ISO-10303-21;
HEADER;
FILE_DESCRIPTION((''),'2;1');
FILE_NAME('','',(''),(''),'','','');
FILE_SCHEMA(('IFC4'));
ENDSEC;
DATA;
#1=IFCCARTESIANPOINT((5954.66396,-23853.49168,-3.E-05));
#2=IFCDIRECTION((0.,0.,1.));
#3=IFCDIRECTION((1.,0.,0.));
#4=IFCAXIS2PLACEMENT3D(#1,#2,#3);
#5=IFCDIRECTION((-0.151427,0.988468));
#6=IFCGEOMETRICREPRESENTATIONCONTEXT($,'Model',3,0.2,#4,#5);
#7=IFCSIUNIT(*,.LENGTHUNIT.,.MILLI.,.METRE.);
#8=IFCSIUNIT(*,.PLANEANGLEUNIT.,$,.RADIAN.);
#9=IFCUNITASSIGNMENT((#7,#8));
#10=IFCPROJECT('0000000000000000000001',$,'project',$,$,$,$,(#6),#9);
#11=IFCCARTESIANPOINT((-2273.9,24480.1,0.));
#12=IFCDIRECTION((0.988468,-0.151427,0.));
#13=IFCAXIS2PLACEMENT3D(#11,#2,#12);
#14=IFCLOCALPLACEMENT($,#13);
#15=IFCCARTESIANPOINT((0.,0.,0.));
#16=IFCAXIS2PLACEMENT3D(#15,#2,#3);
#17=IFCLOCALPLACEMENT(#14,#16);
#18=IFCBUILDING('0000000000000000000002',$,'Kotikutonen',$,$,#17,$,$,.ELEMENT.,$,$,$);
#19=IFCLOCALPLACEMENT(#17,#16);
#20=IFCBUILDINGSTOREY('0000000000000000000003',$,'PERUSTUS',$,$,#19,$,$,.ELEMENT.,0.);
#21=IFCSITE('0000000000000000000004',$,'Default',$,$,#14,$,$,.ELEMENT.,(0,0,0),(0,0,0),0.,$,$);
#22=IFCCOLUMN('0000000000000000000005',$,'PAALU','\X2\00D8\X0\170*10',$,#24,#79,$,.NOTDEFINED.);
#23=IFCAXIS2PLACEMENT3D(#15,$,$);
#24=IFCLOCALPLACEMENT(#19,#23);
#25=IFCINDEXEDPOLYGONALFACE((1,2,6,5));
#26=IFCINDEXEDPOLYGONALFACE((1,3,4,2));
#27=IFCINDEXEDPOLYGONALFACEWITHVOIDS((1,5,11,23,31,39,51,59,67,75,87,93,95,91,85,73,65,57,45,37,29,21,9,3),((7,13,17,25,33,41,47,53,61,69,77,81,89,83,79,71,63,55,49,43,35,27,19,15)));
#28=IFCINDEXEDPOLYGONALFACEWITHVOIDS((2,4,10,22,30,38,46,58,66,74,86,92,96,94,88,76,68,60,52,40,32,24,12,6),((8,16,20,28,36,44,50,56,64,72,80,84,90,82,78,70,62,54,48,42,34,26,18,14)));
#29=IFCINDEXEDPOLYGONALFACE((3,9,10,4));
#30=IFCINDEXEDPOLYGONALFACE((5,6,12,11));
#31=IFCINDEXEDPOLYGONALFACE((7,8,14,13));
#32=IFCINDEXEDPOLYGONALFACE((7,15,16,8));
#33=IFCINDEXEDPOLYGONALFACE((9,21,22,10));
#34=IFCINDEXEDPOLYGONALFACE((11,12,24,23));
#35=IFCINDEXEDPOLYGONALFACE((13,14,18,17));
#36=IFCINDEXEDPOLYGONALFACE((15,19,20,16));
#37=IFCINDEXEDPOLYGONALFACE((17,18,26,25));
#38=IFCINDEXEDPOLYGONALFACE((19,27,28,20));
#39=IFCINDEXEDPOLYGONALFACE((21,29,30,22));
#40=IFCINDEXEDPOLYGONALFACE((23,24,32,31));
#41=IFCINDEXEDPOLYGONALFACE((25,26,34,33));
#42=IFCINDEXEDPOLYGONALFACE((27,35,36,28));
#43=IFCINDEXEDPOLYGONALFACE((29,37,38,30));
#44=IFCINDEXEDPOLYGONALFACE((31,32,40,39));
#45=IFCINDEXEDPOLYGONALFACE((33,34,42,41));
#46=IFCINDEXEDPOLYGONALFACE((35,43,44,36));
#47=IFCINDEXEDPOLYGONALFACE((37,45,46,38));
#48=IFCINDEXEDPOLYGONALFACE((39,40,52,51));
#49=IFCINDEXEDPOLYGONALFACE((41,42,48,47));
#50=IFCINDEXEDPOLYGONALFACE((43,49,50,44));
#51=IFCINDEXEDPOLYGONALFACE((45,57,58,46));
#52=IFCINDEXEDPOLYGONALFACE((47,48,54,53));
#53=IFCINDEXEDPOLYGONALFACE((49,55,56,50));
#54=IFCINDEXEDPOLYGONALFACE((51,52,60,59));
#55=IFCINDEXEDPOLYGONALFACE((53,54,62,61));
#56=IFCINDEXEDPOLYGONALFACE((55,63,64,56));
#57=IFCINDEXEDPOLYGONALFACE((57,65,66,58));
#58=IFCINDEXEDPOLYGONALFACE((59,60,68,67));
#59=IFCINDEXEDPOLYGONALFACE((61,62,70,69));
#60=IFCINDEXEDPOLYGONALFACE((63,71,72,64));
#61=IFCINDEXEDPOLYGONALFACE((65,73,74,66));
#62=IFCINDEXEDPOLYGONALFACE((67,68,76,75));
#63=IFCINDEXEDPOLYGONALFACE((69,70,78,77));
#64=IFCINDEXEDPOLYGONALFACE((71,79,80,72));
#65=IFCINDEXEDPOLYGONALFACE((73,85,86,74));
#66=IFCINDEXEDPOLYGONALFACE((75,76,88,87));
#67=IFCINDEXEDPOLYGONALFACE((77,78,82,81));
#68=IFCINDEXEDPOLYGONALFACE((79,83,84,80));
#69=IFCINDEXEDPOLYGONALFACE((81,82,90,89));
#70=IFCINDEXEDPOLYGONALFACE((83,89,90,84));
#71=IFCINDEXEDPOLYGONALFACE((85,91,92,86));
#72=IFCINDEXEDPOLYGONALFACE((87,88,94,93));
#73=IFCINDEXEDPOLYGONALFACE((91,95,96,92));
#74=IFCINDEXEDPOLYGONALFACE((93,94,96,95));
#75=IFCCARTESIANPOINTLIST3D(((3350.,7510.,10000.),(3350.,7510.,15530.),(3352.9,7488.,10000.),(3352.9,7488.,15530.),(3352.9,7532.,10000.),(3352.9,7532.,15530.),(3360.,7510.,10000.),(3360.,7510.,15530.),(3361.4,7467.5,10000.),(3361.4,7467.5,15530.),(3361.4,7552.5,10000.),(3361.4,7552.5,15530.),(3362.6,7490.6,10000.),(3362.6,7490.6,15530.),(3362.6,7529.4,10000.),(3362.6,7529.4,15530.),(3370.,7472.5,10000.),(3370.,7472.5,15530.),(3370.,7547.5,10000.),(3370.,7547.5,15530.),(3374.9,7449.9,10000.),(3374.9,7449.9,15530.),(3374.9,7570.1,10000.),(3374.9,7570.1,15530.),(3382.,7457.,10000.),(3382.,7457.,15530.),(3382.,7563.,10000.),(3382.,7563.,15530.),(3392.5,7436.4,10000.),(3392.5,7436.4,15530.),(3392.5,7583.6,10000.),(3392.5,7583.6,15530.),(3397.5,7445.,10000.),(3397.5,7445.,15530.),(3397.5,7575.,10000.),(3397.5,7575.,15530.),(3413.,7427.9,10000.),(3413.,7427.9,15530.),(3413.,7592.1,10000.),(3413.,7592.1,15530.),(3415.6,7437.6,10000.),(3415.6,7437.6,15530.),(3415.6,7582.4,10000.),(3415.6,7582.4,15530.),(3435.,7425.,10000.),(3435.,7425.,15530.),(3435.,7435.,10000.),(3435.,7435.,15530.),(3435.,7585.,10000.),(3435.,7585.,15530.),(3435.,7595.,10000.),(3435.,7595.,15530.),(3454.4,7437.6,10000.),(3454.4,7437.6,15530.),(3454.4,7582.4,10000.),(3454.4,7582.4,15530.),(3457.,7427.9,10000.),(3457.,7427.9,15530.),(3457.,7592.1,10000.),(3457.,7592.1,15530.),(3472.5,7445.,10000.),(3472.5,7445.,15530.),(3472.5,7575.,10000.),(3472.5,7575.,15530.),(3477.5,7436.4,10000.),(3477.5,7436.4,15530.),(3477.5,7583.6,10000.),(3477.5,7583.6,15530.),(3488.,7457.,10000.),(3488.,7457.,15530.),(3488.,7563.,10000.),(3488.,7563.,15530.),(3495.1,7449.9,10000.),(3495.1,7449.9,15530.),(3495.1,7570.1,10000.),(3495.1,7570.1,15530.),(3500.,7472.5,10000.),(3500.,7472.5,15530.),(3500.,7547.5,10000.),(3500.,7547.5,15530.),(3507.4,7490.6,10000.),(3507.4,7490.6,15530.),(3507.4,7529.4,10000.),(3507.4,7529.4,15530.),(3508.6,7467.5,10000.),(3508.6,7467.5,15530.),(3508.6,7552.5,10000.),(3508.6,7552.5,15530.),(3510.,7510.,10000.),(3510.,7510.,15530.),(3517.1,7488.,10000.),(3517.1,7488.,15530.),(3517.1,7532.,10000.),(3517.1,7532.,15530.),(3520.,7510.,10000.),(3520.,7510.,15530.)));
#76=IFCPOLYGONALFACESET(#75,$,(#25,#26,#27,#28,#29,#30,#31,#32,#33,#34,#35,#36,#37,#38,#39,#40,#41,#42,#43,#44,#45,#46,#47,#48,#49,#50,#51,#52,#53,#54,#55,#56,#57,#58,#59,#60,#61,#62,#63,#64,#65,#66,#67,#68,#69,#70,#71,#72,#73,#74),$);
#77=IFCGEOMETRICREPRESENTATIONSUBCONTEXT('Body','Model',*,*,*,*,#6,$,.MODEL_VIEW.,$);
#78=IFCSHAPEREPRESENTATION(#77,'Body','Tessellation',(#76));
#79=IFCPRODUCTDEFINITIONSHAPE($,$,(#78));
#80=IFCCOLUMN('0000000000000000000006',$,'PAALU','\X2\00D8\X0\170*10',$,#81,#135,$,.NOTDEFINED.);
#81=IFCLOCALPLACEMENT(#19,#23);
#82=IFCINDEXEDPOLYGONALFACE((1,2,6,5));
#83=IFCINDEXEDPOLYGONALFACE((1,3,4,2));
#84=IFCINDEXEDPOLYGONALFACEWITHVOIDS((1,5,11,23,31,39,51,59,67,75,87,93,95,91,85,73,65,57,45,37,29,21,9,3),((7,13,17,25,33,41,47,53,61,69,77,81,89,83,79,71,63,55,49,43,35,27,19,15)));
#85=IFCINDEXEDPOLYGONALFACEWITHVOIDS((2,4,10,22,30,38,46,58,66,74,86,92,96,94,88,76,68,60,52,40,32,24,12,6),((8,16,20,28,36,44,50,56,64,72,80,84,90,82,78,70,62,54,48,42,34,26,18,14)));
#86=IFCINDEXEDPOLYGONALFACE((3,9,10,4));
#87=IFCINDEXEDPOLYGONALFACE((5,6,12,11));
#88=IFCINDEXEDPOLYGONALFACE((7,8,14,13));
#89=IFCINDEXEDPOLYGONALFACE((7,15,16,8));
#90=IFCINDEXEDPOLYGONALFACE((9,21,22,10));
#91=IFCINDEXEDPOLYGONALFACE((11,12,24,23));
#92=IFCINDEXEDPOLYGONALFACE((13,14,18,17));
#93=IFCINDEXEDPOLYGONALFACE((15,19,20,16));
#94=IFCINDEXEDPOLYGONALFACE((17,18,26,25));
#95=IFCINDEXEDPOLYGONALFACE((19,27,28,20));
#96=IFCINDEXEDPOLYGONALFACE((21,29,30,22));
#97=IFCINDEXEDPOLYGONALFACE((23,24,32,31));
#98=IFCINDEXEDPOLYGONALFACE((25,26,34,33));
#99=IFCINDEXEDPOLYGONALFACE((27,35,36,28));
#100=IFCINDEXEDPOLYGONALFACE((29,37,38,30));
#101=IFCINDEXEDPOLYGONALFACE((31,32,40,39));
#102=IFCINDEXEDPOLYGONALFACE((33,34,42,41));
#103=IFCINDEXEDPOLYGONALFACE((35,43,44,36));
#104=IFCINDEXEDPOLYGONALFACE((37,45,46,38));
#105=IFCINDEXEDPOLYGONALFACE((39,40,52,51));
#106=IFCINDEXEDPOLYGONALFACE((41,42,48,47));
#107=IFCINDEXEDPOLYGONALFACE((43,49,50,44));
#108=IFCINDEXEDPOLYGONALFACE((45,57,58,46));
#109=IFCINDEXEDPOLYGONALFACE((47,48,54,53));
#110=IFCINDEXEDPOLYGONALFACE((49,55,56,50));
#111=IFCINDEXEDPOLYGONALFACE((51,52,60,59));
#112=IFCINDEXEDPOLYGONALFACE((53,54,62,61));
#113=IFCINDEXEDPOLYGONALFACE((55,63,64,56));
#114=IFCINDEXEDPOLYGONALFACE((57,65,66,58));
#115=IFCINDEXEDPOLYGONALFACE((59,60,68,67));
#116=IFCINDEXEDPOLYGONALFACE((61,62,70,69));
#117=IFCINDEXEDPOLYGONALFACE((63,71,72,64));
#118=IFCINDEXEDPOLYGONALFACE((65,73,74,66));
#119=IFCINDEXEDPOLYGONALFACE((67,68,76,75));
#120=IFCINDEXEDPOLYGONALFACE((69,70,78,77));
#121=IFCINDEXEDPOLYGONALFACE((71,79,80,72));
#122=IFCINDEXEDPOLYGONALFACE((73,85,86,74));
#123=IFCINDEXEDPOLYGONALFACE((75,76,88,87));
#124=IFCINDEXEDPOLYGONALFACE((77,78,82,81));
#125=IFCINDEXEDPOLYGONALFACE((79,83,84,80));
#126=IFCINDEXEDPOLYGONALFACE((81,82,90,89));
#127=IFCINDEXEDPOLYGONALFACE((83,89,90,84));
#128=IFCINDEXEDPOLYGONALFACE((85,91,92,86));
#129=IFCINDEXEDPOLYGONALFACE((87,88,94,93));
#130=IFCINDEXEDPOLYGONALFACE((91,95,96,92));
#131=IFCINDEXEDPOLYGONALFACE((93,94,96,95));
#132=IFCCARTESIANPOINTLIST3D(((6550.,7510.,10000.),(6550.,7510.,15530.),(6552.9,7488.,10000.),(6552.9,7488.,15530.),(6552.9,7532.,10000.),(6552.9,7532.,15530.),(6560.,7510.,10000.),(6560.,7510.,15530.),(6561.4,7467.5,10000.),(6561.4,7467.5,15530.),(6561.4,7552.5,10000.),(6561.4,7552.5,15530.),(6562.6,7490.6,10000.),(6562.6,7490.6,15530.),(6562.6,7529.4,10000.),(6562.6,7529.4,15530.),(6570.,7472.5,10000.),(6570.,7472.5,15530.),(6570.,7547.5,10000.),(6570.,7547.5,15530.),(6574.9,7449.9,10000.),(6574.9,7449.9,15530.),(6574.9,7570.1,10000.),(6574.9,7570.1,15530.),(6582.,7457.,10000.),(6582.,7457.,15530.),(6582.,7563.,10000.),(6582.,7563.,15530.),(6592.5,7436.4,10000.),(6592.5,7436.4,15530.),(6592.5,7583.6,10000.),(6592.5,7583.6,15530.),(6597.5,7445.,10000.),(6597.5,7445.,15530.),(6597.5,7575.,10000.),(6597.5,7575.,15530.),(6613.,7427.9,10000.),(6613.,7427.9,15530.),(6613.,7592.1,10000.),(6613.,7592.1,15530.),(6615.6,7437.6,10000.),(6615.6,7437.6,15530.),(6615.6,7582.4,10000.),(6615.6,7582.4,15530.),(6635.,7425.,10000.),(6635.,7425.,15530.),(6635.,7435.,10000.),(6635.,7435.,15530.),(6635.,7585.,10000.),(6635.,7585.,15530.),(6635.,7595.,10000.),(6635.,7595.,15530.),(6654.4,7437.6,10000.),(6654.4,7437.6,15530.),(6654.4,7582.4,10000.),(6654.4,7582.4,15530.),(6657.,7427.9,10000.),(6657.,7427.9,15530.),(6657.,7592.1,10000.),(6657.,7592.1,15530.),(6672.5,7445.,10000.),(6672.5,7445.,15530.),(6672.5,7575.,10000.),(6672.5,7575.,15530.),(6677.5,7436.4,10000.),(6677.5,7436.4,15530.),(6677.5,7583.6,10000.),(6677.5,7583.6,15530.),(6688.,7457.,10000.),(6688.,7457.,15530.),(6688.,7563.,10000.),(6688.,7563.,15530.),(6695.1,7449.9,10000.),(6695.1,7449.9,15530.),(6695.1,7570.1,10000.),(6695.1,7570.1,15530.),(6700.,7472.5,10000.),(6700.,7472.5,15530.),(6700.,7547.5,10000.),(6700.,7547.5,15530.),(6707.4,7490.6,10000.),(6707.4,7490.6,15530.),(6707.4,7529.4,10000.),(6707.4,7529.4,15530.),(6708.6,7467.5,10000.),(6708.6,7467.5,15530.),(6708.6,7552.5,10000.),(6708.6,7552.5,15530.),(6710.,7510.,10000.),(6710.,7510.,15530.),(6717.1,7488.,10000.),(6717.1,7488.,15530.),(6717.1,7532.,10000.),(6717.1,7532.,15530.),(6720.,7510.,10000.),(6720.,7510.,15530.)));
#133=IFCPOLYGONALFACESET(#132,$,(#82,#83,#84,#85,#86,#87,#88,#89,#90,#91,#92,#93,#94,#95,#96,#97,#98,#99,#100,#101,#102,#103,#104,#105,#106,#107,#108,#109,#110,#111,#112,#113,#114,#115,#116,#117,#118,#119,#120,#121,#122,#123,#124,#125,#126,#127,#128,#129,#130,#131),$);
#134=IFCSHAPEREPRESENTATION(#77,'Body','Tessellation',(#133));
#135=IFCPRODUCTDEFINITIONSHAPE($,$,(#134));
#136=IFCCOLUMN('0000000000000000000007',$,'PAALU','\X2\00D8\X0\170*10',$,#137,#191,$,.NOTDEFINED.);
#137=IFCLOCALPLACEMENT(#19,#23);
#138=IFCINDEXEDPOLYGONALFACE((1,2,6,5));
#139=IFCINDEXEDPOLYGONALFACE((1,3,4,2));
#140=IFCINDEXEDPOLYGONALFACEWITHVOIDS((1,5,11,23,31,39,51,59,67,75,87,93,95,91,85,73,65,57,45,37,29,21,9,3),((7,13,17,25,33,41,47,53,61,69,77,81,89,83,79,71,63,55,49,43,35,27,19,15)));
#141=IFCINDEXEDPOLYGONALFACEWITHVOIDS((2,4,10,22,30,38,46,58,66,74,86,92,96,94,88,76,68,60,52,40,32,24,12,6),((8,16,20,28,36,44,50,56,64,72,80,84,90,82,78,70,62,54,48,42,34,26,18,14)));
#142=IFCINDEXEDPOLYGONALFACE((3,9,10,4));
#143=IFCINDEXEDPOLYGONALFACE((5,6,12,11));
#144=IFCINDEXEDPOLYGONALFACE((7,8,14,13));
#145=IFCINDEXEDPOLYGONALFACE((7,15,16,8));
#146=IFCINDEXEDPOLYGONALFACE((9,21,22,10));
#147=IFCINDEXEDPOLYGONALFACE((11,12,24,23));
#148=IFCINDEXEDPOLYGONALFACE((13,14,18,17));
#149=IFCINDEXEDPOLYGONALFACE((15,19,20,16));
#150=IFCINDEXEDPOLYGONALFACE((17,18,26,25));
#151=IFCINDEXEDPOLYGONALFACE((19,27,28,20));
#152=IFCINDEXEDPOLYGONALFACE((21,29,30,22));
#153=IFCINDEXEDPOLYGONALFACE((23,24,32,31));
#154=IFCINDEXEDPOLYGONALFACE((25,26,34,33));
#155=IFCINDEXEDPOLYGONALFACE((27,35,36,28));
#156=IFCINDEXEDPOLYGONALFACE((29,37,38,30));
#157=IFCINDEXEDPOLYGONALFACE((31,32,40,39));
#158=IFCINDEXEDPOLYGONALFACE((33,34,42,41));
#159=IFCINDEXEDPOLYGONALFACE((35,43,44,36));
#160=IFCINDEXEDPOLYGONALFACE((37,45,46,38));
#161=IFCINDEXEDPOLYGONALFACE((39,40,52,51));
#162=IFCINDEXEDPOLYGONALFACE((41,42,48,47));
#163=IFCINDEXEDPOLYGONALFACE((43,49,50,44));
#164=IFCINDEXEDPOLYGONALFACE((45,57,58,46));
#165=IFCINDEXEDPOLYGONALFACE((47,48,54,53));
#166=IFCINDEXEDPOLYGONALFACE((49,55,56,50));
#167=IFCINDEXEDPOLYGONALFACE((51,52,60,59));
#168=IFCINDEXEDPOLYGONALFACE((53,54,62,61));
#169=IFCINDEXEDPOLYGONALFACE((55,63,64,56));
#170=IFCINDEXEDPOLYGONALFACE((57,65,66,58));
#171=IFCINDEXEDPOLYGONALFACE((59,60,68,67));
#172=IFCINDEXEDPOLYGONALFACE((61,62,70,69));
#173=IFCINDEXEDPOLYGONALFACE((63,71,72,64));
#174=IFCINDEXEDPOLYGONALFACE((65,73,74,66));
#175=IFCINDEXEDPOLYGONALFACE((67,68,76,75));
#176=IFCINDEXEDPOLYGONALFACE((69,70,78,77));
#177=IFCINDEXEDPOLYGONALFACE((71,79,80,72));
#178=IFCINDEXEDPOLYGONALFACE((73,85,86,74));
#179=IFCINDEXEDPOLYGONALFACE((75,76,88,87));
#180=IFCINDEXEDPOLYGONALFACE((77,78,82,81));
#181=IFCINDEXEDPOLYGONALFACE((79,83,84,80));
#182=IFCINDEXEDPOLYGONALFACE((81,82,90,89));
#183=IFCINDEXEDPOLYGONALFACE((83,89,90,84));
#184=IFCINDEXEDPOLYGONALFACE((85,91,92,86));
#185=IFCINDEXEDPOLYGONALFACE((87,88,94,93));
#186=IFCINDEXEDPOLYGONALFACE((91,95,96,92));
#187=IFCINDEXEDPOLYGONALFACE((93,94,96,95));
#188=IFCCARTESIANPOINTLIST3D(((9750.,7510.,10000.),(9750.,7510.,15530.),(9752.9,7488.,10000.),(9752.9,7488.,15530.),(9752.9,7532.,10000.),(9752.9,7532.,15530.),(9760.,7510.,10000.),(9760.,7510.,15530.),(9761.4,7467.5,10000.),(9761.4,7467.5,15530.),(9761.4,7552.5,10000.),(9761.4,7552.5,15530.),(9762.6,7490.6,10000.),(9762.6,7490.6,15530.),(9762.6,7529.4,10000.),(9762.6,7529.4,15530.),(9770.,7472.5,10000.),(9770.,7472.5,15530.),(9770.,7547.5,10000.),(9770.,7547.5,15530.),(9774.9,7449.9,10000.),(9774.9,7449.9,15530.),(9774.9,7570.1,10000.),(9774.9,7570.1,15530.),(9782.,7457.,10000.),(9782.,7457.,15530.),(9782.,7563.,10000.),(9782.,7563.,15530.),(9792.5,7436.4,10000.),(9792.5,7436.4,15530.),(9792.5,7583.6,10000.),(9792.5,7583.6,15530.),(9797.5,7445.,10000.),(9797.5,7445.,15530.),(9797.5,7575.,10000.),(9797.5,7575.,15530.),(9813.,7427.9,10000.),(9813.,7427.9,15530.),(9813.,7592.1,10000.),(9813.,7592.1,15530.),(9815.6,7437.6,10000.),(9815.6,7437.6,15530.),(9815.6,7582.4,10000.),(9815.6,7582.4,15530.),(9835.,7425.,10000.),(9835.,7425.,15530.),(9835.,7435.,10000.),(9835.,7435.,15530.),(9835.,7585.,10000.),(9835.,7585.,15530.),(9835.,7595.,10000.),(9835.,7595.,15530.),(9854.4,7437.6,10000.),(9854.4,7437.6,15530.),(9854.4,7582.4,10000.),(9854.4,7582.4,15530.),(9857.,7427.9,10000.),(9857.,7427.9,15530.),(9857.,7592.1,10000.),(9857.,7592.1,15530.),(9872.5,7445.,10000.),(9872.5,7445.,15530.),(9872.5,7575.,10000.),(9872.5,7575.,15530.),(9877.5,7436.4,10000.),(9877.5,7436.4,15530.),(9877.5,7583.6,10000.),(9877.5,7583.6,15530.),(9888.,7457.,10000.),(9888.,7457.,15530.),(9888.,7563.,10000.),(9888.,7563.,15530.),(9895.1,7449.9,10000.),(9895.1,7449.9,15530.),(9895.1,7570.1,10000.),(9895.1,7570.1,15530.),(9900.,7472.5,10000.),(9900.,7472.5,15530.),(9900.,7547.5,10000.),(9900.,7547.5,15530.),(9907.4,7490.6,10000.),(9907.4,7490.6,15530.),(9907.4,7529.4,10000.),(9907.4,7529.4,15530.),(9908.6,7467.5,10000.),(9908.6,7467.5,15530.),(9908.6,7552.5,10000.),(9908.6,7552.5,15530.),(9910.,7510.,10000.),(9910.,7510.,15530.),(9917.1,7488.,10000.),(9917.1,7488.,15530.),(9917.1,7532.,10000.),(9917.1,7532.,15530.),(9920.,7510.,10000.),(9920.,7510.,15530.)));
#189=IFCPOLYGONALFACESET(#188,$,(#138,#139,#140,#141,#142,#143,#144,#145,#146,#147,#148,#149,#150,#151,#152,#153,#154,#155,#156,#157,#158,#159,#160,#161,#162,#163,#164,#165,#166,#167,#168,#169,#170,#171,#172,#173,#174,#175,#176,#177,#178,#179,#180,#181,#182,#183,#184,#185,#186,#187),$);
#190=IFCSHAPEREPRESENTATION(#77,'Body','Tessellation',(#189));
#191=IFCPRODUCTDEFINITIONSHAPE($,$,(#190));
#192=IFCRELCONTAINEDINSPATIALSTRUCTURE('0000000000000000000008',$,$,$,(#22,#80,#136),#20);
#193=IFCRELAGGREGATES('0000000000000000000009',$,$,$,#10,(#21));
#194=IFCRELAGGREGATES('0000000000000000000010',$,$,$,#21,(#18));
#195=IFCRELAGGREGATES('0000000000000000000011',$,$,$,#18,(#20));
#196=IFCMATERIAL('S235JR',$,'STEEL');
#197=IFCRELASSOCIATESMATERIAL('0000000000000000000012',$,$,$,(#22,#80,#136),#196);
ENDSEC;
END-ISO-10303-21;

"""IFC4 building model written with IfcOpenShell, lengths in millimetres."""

from ifc_helpers import new_model, si_unit, direction, frame, origin_with_axes, place, context, subcontext, project, spatial, line, indexed_curve, outline, extrude, material, element, save


model = new_model("IFC4")

# Units and contexts
model_context = context("Model", 3, precision=0.2, world=frame((5954.66396, -23853.49168, -3e-05), z_axis=(0.0, 0.0, 1.0), x_axis=(1.0, 0.0, 0.0)), true_north=direction((-0.151427, 0.988468)))
body_context = subcontext(model_context, "Body", "Model", "MODEL_VIEW")
ifc_project = project(units=[si_unit("LENGTHUNIT", "METRE", prefix="MILLI"), si_unit("PLANEANGLEUNIT", "RADIAN")], contexts=[model_context])

# Site, building, storey
site_placement = place(None, frame((-2273.9, 24480.1, 0.0), z_axis=(0.0, 0.0, 1.0), x_axis=(0.988468, -0.151427, 0.0)))
site = spatial("IfcSite", under=ifc_project, at=site_placement, Name="Default", CompositionType="ELEMENT", RefLatitude=(0, 0, 0), RefLongitude=(0, 0, 0), RefElevation=0.0)
building_placement = place(site_placement, origin_with_axes())
building = spatial("IfcBuilding", under=site, at=building_placement, Name="Kotikutonen", CompositionType="ELEMENT")
storey_placement = place(building_placement, origin_with_axes())
storey = spatial("IfcBuildingStorey", under=building, at=storey_placement, Name="PERUSTUS", CompositionType="ELEMENT", Elevation=0.0)

# Columns
ifc_material = material(Name="S235JR", Category="STEEL")
for number, where, z_axis, x_axis, name in (
    (1, (3435.0, 7510.0, 10000.0), (-1.0, 0.0, 0.0), (0.0, 0.0, 1.0), "PAALU"),
    (2, (6635.0, 7510.0, 10000.0), (-1.0, 0.0, 0.0), (0.0, 0.0, 1.0), "PAALU"),
    (3, (9835.0, 7510.0, 10000.0), (-1.0, 0.0, 0.0), (0.0, 0.0, 1.0), "PAALU"),
):
    element("IfcColumn", number, at=place(storey_placement, frame(where, z_axis=z_axis, x_axis=x_axis)), inside=storey, material=ifc_material, Name=name, Description="Ø170*10", PredefinedType="NOTDEFINED", context=body_context, shape_type="SolidModel", body=[
        extrude(outline(indexed_curve([(85.0, 0.0), (82.1, 22.0), (73.6, 42.5), (60.1, 60.1), (42.5, 73.6), (22.0, 82.1), (0.0, 85.0), (-22.0, 82.1), (-42.5, 73.6), (-60.1, 60.1), (-73.6, 42.5), (-82.1, 22.0), (-85.0, 0.0), (-82.1, -22.0), (-73.6, -42.5), (-60.1, -60.1), (-42.5, -73.6), (-22.0, -82.1), (0.0, -85.0), (22.0, -82.1), (42.5, -73.6), (60.1, -60.1), (73.6, -42.5), (82.1, -22.0)], segments=[line(1, 2, 3, 4, 5, 6, 7, 8, 9, 10, 11, 12, 13, 14, 15, 16, 17, 18, 19, 20, 21, 22, 23, 24, 1)]), holes=[indexed_curve([(75.0, 0.0), (72.4, -19.4), (65.0, -37.5), (53.0, -53.0), (37.5, -65.0), (19.4, -72.4), (0.0, -75.0), (-19.4, -72.4), (-37.5, -65.0), (-53.0, -53.0), (-65.0, -37.5), (-72.4, -19.4), (-75.0, 0.0), (-72.4, 19.4), (-65.0, 37.5), (-53.0, 53.0), (-37.5, 65.0), (-19.4, 72.4), (0.0, 75.0), (19.4, 72.4), (37.5, 65.0), (53.0, 53.0), (65.0, 37.5), (72.4, 19.4)], segments=[line(1, 2, 3, 4, 5, 6, 7, 8, 9, 10, 11, 12, 13, 14, 15, 16, 17, 18, 19, 20, 21, 22, 23, 24, 1)])]), frame((0.0, 0.0, 0.0), z_axis=(-1.0, 0.0, 0.0), x_axis=(0.0, 0.0, 1.0)), (0.0, 0.0, -1.0), 5530.0),
    ])

save(model, "model.ifc")
